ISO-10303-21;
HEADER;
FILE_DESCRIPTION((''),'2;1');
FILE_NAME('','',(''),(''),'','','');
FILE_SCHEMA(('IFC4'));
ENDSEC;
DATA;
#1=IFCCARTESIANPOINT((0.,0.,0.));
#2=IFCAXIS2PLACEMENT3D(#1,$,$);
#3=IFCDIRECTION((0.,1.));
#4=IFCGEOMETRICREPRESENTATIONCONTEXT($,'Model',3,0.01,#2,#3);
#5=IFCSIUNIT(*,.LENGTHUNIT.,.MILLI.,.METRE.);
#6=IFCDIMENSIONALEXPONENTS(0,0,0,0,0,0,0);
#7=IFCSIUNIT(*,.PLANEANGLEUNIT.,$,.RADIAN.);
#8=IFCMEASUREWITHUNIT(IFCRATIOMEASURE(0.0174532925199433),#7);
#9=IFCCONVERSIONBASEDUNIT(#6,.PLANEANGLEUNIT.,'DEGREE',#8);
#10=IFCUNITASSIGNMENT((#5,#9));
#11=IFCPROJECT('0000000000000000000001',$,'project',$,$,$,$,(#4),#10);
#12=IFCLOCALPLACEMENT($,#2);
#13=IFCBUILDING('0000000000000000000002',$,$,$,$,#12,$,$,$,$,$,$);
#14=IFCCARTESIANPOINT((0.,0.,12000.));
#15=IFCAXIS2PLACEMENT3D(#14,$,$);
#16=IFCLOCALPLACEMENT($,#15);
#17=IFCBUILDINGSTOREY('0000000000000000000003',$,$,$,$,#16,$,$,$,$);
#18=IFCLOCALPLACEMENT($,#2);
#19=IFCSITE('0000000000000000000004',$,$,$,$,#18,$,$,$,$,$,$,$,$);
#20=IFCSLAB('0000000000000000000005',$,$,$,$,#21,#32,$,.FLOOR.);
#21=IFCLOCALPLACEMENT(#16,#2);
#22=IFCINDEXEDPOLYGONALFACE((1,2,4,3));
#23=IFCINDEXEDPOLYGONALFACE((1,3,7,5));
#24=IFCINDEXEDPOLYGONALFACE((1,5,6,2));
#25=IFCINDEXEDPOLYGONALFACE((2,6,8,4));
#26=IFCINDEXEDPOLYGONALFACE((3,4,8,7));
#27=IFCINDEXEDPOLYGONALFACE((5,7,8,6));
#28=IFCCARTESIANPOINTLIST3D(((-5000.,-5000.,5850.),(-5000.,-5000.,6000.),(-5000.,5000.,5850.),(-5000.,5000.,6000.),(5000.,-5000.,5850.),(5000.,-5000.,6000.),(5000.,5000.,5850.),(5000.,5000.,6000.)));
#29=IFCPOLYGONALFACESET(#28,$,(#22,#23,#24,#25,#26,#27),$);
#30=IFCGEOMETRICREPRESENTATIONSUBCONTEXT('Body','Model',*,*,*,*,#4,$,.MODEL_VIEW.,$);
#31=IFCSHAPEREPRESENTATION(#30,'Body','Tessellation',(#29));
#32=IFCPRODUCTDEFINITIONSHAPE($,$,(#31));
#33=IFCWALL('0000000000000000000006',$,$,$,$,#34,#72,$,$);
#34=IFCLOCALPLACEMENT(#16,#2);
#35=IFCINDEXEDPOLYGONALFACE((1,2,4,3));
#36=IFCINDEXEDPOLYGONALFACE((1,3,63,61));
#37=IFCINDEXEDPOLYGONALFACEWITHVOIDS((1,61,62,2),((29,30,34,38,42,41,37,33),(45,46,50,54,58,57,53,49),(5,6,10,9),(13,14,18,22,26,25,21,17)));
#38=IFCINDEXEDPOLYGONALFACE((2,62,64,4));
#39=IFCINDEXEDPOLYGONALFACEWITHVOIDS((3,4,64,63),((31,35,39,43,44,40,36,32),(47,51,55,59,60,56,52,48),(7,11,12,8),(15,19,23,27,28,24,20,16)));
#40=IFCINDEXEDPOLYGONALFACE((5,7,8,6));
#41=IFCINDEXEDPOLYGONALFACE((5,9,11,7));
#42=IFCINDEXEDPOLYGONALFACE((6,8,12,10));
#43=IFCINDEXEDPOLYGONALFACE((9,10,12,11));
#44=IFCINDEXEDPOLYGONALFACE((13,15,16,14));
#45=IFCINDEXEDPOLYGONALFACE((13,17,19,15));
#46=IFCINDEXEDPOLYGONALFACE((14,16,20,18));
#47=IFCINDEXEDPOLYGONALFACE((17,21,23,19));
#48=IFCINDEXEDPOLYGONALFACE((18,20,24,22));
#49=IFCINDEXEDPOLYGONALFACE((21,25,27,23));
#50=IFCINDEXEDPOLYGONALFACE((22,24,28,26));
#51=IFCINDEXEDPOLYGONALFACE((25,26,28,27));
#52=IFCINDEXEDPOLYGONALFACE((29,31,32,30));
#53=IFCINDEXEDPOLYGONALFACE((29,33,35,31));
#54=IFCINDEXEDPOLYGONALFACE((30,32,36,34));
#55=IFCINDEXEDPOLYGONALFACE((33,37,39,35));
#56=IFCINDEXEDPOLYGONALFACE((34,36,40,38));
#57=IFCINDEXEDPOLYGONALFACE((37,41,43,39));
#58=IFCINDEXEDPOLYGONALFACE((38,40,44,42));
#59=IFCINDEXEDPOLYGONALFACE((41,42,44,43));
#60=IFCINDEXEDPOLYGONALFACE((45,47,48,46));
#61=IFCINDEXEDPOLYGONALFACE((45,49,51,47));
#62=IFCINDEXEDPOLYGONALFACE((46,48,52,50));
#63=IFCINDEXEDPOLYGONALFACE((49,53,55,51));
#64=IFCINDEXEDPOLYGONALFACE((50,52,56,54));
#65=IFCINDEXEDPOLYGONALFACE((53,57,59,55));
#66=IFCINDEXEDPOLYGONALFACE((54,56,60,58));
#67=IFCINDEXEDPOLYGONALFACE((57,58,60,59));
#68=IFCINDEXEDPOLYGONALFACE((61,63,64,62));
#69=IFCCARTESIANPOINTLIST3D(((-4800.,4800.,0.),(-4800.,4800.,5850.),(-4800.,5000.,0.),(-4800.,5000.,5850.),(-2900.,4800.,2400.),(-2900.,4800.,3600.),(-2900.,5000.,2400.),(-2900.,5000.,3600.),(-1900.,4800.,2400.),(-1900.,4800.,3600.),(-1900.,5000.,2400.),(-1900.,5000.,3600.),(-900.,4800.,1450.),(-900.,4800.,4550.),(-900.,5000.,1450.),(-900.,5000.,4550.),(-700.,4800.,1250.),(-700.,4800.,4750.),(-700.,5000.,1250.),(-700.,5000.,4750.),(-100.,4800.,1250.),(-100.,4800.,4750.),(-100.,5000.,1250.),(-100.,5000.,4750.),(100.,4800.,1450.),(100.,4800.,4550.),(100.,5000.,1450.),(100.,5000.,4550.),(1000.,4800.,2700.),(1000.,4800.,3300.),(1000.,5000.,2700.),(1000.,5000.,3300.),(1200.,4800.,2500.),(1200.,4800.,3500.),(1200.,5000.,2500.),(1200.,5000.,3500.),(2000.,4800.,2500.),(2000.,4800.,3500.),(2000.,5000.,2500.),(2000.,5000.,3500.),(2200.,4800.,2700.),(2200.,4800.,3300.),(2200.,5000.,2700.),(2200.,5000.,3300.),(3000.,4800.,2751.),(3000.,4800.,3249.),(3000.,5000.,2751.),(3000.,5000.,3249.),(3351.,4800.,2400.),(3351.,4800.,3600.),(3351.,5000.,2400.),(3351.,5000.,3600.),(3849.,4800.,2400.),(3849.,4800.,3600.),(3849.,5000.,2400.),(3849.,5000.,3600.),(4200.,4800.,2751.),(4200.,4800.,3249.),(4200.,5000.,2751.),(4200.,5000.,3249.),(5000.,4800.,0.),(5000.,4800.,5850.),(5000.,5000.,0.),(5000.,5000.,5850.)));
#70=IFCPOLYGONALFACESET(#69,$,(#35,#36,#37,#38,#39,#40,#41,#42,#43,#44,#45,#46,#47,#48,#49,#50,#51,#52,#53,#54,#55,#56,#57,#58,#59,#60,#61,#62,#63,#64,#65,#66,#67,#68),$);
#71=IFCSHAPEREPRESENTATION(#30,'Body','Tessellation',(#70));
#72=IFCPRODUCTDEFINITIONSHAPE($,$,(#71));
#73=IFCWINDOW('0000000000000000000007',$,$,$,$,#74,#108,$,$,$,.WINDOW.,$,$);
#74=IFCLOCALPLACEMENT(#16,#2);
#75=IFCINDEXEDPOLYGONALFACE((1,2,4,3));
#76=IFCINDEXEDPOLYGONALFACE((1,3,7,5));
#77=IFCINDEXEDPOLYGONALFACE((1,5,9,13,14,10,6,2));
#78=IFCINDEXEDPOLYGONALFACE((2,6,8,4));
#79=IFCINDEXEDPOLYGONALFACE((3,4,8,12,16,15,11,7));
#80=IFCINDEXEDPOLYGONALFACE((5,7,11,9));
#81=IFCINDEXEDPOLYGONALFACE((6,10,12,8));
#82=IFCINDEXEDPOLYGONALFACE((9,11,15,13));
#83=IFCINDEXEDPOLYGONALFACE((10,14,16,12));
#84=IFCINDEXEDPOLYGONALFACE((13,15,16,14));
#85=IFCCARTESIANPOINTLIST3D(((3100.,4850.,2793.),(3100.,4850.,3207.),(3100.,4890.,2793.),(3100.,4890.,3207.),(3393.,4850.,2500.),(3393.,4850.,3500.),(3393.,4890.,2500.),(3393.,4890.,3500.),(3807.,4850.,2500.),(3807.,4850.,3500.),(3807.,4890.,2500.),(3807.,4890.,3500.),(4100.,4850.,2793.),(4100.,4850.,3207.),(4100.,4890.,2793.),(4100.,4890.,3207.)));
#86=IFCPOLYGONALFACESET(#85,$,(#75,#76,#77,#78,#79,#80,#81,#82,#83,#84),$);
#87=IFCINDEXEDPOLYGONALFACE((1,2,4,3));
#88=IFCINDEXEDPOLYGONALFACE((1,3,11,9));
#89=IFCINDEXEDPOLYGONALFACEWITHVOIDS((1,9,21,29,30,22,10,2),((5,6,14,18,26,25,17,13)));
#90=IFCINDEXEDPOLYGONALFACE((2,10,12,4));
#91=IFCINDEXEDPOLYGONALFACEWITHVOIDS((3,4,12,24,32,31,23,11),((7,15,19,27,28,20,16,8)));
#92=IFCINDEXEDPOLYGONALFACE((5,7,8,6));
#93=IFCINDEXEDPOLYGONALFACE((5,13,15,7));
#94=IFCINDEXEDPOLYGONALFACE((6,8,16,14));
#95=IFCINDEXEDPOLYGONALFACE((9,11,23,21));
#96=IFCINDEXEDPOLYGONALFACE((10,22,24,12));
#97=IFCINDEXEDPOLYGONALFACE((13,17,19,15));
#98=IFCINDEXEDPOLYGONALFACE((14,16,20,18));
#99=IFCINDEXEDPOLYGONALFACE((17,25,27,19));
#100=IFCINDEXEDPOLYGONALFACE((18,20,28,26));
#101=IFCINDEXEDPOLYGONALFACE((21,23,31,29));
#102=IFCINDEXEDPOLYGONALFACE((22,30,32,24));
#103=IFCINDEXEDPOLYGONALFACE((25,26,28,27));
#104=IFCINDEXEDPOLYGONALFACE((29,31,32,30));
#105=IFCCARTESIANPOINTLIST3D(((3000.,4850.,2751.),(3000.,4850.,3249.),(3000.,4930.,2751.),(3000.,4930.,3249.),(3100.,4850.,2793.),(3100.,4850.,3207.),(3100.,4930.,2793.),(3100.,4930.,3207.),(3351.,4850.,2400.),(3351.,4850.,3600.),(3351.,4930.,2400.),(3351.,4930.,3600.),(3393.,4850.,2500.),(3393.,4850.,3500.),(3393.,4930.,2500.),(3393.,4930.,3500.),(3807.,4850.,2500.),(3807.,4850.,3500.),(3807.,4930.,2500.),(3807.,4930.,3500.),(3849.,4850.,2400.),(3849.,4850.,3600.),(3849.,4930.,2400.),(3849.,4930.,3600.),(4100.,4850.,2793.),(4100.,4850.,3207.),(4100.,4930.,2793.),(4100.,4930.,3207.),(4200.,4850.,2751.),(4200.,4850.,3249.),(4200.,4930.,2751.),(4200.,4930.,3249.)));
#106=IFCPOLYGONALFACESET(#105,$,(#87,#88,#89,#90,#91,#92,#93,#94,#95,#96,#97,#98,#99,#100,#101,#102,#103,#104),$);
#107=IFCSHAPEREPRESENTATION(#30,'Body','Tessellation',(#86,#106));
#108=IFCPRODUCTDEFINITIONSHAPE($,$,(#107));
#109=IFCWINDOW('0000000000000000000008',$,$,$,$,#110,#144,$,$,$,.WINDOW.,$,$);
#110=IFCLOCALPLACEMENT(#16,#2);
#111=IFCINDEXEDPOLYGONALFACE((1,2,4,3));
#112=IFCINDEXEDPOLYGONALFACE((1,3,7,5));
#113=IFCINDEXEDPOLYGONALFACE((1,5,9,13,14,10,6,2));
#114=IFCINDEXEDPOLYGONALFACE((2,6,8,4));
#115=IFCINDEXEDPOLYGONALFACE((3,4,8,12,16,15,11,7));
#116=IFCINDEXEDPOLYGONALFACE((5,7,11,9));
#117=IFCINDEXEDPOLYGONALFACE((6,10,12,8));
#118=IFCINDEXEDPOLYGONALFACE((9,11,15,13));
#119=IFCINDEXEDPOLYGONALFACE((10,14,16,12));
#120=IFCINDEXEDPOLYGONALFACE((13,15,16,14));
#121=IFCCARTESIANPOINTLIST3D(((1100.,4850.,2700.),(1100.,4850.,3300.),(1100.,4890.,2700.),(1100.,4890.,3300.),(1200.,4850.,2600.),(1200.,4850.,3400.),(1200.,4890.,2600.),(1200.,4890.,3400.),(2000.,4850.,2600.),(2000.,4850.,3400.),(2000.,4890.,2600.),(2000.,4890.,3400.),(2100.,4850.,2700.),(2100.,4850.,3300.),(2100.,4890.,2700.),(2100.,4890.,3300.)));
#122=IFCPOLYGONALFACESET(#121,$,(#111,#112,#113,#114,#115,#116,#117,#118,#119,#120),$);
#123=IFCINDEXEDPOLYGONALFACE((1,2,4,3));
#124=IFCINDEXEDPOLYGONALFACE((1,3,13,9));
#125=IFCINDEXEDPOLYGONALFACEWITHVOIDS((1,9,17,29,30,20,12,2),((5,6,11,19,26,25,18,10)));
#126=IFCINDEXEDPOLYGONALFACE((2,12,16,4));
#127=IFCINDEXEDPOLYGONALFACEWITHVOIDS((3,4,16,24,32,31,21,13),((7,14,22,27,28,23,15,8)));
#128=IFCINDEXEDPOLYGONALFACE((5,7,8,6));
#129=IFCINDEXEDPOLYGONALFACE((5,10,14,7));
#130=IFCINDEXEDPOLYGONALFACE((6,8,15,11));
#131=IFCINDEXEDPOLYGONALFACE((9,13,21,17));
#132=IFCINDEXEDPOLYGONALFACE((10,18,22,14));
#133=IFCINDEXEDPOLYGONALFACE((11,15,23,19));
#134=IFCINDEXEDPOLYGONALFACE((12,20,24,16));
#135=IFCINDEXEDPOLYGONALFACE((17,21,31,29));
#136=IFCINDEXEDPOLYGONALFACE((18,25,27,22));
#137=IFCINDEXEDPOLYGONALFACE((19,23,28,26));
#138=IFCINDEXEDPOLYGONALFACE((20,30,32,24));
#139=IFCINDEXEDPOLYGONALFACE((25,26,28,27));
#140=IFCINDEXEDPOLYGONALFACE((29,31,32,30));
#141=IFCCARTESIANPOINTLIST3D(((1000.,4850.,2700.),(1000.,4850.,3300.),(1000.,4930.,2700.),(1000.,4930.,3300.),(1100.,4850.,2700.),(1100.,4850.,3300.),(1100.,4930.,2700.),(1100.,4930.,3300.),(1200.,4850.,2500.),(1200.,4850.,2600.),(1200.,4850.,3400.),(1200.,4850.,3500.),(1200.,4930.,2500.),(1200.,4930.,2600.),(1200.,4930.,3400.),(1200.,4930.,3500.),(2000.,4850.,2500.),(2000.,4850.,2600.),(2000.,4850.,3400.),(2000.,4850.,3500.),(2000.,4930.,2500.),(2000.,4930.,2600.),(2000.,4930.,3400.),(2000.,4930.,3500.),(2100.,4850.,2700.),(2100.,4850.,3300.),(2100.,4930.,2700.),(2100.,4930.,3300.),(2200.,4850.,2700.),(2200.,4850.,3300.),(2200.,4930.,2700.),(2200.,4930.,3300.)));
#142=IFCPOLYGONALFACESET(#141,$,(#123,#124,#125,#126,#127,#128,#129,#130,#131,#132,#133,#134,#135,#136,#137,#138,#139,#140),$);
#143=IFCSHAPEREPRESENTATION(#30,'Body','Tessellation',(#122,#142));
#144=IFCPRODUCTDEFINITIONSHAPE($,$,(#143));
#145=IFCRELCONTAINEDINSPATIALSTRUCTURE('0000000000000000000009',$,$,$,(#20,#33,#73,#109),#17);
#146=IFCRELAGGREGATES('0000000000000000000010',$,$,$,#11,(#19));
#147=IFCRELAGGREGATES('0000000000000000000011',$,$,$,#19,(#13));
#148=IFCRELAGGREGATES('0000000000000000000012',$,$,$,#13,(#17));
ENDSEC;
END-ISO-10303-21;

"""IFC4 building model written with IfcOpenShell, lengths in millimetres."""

from ifc_helpers import new_model, entity, si_unit, converted_unit, direction, frame, origin, origin_2d, place, context, subcontext, project, spatial, polyline, rectangle, outline, extrude, element, save


model = new_model("IFC4")

# Units and contexts
model_context = context("Model", 3, precision=0.01, world=origin(), true_north=direction((0.0, 1.0)))
body_context = subcontext(model_context, "Body", "Model", "MODEL_VIEW")
ifc_project = project(units=[si_unit("LENGTHUNIT", "METRE", prefix="MILLI"), converted_unit("PLANEANGLEUNIT", "DEGREE", entity("IfcRatioMeasure", 0.0174532925199433), si_unit("PLANEANGLEUNIT", "RADIAN"), dimensions=[0, 0, 0, 0, 0, 0, 0])], contexts=[model_context])

# Site, building, storey
site_placement = place(None, origin())
site = spatial("IfcSite", under=ifc_project, at=site_placement)
building_placement = place(None, origin())
building = spatial("IfcBuilding", under=site, at=building_placement)
storey_placement = place(None, frame((0.0, 0.0, 12000.0)))
storey = spatial("IfcBuildingStorey", under=building, at=storey_placement)

# Slab
slab_placement = place(storey_placement, frame((0.0, 0.0, 5850.0)))
element("IfcSlab", 1, at=slab_placement, inside=storey, PredefinedType="FLOOR", context=body_context, shape_type="SweptSolid", body=[
    extrude(rectangle(XDim=10000.0, YDim=10000.0, at=origin_2d()), origin(), (0.0, 0.0, 1.0), 150.0),
])

# Wall, openings
wall_1_placement = place(storey_placement, frame((100.0, 4900.0, 0.0), z_axis=(0.0, 0.0, 1.0), x_axis=(-1.0, 0.0, 0.0)))
wall_1 = element("IfcWall", 2, at=wall_1_placement, inside=storey, context=body_context, shape_type="SweptSolid", body=[
    extrude(rectangle(XDim=9800.0, YDim=200.0, at=origin_2d()), origin(), (0.0, 0.0, 1.0), 5850.0),
])
window_1_placement = place(wall_1_placement, frame((-3500.0, 50.0, 3000.0)))
opening_1_placement = place(window_1_placement, frame((0.0, 50.0, 0.0)))
element("IfcOpeningElement", 3, at=opening_1_placement, cuts=wall_1, context=body_context, shape_type="SweptSolid", body=[
    extrude(outline(polyline([(-600.0, -249.0), (-600.0, 249.0), (-249.0, 600.0), (249.0, 600.0), (600.0, 249.0), (600.0, -249.0), (249.0, -600.0), (-249.0, -600.0), (-600.0, -249.0)])), frame((0.0, 0.0, 0.0), z_axis=(0.0, -1.0, 0.0), x_axis=(1.0, 0.0, 0.0)), (0.0, 0.0, 1.0), 200.0),
])
window_2_placement = place(wall_1_placement, frame((-1500.0, 50.0, 3000.0)))
opening_2_placement = place(window_2_placement, frame((0.0, 50.0, 0.0)))
element("IfcOpeningElement", 4, at=opening_2_placement, cuts=wall_1, context=body_context, shape_type="SweptSolid", body=[
    extrude(outline(polyline([(-600.0, -300.0), (-600.0, 300.0), (-400.0, 500.0), (400.0, 500.0), (600.0, 300.0), (600.0, -300.0), (400.0, -500.0), (-400.0, -500.0), (-600.0, -300.0)])), frame((0.0, 0.0, 0.0), z_axis=(0.0, -1.0, 0.0), x_axis=(1.0, 0.0, 0.0)), (0.0, 0.0, 1.0), 200.0),
])
window_3_placement = place(wall_1_placement, frame((500.0, 50.0, 3000.0)))
opening_3_placement = place(window_3_placement, frame((0.0, 50.0, 0.0)))
element("IfcOpeningElement", 5, at=opening_3_placement, cuts=wall_1, context=body_context, shape_type="SweptSolid", body=[
    extrude(outline(polyline([(-500.0, -1550.0), (-500.0, 1550.0), (-300.0, 1750.0), (300.0, 1750.0), (500.0, 1550.0), (500.0, -1550.0), (300.0, -1750.0), (-300.0, -1750.0), (-500.0, -1550.0)])), frame((0.0, 0.0, 0.0), z_axis=(0.0, -1.0, 0.0), x_axis=(1.0, 0.0, 0.0)), (0.0, 0.0, 1.0), 200.0),
])
window_4_placement = place(wall_1_placement, frame((2500.0, 50.0, 3000.0)))
opening_4_placement = place(window_4_placement, frame((0.0, 50.0, 0.0)))
element("IfcOpeningElement", 6, at=opening_4_placement, cuts=wall_1, context=body_context, shape_type="SweptSolid", body=[
    extrude(outline(polyline([(-500.0, -600.0), (-500.0, 600.0), (-500.0, 600.0), (500.0, 600.0), (500.0, 600.0), (500.0, -600.0), (500.0, -600.0), (-500.0, -600.0), (-500.0, -600.0)])), frame((0.0, 0.0, 0.0), z_axis=(0.0, -1.0, 0.0), x_axis=(1.0, 0.0, 0.0)), (0.0, 0.0, 1.0), 200.0),
])

# Windows
cartesian_point_1 = entity("IfcCartesianPoint", [-500.0, -207.0])
shared_polyline_1 = entity("IfcPolyline", [cartesian_point_1, entity("IfcCartesianPoint", [-500.0, 207.0]), entity("IfcCartesianPoint", [-207.0, 500.0]), entity("IfcCartesianPoint", [207.0, 500.0]), entity("IfcCartesianPoint", [500.0, 207.0]), entity("IfcCartesianPoint", [500.0, -207.0]), entity("IfcCartesianPoint", [207.0, -500.0]), entity("IfcCartesianPoint", [-207.0, -500.0]), cartesian_point_1])
cartesian_point_2 = entity("IfcCartesianPoint", [-600.0, -249.0])
element("IfcWindow", 7, at=window_1_placement, inside=storey, PredefinedType="WINDOW", context=body_context, shape_type="SweptSolid", body=[
    entity("IfcExtrudedAreaSolid", entity("IfcArbitraryClosedProfileDef", "AREA", None, shared_polyline_1), entity("IfcAxis2Placement3D", entity("IfcCartesianPoint", [0.0, 0.0, 0.0]), entity("IfcDirection", [0.0, -1.0, 0.0]), entity("IfcDirection", [1.0, 0.0, 0.0])), entity("IfcDirection", [0.0, 0.0, 1.0]), 40.0),
    entity("IfcExtrudedAreaSolid", entity("IfcArbitraryProfileDefWithVoids", "AREA", None, entity("IfcPolyline", [cartesian_point_2, entity("IfcCartesianPoint", [-600.0, 249.0]), entity("IfcCartesianPoint", [-249.0, 600.0]), entity("IfcCartesianPoint", [249.0, 600.0]), entity("IfcCartesianPoint", [600.0, 249.0]), entity("IfcCartesianPoint", [600.0, -249.0]), entity("IfcCartesianPoint", [249.0, -600.0]), entity("IfcCartesianPoint", [-249.0, -600.0]), cartesian_point_2]), [shared_polyline_1]), entity("IfcAxis2Placement3D", entity("IfcCartesianPoint", [0.0, 0.0, 0.0]), entity("IfcDirection", [0.0, -1.0, 0.0]), entity("IfcDirection", [1.0, 0.0, 0.0])), entity("IfcDirection", [0.0, 0.0, 1.0]), 80.0),
])
cartesian_point_3 = entity("IfcCartesianPoint", [-500.0, -300.0])
shared_polyline_2 = entity("IfcPolyline", [cartesian_point_3, entity("IfcCartesianPoint", [-500.0, 300.0]), entity("IfcCartesianPoint", [-400.0, 400.0]), entity("IfcCartesianPoint", [400.0, 400.0]), entity("IfcCartesianPoint", [500.0, 300.0]), entity("IfcCartesianPoint", [500.0, -300.0]), entity("IfcCartesianPoint", [400.0, -400.0]), entity("IfcCartesianPoint", [-400.0, -400.0]), cartesian_point_3])
cartesian_point_4 = entity("IfcCartesianPoint", [-600.0, -300.0])
element("IfcWindow", 8, at=window_2_placement, inside=storey, PredefinedType="WINDOW", context=body_context, shape_type="SweptSolid", body=[
    entity("IfcExtrudedAreaSolid", entity("IfcArbitraryClosedProfileDef", "AREA", None, shared_polyline_2), entity("IfcAxis2Placement3D", entity("IfcCartesianPoint", [0.0, 0.0, 0.0]), entity("IfcDirection", [0.0, -1.0, 0.0]), entity("IfcDirection", [1.0, 0.0, 0.0])), entity("IfcDirection", [0.0, 0.0, 1.0]), 40.0),
    entity("IfcExtrudedAreaSolid", entity("IfcArbitraryProfileDefWithVoids", "AREA", None, entity("IfcPolyline", [cartesian_point_4, entity("IfcCartesianPoint", [-600.0, 300.0]), entity("IfcCartesianPoint", [-400.0, 500.0]), entity("IfcCartesianPoint", [400.0, 500.0]), entity("IfcCartesianPoint", [600.0, 300.0]), entity("IfcCartesianPoint", [600.0, -300.0]), entity("IfcCartesianPoint", [400.0, -500.0]), entity("IfcCartesianPoint", [-400.0, -500.0]), cartesian_point_4]), [shared_polyline_2]), entity("IfcAxis2Placement3D", entity("IfcCartesianPoint", [0.0, 0.0, 0.0]), entity("IfcDirection", [0.0, -1.0, 0.0]), entity("IfcDirection", [1.0, 0.0, 0.0])), entity("IfcDirection", [0.0, 0.0, 1.0]), 80.0),
])

save(model, "model.ifc")
